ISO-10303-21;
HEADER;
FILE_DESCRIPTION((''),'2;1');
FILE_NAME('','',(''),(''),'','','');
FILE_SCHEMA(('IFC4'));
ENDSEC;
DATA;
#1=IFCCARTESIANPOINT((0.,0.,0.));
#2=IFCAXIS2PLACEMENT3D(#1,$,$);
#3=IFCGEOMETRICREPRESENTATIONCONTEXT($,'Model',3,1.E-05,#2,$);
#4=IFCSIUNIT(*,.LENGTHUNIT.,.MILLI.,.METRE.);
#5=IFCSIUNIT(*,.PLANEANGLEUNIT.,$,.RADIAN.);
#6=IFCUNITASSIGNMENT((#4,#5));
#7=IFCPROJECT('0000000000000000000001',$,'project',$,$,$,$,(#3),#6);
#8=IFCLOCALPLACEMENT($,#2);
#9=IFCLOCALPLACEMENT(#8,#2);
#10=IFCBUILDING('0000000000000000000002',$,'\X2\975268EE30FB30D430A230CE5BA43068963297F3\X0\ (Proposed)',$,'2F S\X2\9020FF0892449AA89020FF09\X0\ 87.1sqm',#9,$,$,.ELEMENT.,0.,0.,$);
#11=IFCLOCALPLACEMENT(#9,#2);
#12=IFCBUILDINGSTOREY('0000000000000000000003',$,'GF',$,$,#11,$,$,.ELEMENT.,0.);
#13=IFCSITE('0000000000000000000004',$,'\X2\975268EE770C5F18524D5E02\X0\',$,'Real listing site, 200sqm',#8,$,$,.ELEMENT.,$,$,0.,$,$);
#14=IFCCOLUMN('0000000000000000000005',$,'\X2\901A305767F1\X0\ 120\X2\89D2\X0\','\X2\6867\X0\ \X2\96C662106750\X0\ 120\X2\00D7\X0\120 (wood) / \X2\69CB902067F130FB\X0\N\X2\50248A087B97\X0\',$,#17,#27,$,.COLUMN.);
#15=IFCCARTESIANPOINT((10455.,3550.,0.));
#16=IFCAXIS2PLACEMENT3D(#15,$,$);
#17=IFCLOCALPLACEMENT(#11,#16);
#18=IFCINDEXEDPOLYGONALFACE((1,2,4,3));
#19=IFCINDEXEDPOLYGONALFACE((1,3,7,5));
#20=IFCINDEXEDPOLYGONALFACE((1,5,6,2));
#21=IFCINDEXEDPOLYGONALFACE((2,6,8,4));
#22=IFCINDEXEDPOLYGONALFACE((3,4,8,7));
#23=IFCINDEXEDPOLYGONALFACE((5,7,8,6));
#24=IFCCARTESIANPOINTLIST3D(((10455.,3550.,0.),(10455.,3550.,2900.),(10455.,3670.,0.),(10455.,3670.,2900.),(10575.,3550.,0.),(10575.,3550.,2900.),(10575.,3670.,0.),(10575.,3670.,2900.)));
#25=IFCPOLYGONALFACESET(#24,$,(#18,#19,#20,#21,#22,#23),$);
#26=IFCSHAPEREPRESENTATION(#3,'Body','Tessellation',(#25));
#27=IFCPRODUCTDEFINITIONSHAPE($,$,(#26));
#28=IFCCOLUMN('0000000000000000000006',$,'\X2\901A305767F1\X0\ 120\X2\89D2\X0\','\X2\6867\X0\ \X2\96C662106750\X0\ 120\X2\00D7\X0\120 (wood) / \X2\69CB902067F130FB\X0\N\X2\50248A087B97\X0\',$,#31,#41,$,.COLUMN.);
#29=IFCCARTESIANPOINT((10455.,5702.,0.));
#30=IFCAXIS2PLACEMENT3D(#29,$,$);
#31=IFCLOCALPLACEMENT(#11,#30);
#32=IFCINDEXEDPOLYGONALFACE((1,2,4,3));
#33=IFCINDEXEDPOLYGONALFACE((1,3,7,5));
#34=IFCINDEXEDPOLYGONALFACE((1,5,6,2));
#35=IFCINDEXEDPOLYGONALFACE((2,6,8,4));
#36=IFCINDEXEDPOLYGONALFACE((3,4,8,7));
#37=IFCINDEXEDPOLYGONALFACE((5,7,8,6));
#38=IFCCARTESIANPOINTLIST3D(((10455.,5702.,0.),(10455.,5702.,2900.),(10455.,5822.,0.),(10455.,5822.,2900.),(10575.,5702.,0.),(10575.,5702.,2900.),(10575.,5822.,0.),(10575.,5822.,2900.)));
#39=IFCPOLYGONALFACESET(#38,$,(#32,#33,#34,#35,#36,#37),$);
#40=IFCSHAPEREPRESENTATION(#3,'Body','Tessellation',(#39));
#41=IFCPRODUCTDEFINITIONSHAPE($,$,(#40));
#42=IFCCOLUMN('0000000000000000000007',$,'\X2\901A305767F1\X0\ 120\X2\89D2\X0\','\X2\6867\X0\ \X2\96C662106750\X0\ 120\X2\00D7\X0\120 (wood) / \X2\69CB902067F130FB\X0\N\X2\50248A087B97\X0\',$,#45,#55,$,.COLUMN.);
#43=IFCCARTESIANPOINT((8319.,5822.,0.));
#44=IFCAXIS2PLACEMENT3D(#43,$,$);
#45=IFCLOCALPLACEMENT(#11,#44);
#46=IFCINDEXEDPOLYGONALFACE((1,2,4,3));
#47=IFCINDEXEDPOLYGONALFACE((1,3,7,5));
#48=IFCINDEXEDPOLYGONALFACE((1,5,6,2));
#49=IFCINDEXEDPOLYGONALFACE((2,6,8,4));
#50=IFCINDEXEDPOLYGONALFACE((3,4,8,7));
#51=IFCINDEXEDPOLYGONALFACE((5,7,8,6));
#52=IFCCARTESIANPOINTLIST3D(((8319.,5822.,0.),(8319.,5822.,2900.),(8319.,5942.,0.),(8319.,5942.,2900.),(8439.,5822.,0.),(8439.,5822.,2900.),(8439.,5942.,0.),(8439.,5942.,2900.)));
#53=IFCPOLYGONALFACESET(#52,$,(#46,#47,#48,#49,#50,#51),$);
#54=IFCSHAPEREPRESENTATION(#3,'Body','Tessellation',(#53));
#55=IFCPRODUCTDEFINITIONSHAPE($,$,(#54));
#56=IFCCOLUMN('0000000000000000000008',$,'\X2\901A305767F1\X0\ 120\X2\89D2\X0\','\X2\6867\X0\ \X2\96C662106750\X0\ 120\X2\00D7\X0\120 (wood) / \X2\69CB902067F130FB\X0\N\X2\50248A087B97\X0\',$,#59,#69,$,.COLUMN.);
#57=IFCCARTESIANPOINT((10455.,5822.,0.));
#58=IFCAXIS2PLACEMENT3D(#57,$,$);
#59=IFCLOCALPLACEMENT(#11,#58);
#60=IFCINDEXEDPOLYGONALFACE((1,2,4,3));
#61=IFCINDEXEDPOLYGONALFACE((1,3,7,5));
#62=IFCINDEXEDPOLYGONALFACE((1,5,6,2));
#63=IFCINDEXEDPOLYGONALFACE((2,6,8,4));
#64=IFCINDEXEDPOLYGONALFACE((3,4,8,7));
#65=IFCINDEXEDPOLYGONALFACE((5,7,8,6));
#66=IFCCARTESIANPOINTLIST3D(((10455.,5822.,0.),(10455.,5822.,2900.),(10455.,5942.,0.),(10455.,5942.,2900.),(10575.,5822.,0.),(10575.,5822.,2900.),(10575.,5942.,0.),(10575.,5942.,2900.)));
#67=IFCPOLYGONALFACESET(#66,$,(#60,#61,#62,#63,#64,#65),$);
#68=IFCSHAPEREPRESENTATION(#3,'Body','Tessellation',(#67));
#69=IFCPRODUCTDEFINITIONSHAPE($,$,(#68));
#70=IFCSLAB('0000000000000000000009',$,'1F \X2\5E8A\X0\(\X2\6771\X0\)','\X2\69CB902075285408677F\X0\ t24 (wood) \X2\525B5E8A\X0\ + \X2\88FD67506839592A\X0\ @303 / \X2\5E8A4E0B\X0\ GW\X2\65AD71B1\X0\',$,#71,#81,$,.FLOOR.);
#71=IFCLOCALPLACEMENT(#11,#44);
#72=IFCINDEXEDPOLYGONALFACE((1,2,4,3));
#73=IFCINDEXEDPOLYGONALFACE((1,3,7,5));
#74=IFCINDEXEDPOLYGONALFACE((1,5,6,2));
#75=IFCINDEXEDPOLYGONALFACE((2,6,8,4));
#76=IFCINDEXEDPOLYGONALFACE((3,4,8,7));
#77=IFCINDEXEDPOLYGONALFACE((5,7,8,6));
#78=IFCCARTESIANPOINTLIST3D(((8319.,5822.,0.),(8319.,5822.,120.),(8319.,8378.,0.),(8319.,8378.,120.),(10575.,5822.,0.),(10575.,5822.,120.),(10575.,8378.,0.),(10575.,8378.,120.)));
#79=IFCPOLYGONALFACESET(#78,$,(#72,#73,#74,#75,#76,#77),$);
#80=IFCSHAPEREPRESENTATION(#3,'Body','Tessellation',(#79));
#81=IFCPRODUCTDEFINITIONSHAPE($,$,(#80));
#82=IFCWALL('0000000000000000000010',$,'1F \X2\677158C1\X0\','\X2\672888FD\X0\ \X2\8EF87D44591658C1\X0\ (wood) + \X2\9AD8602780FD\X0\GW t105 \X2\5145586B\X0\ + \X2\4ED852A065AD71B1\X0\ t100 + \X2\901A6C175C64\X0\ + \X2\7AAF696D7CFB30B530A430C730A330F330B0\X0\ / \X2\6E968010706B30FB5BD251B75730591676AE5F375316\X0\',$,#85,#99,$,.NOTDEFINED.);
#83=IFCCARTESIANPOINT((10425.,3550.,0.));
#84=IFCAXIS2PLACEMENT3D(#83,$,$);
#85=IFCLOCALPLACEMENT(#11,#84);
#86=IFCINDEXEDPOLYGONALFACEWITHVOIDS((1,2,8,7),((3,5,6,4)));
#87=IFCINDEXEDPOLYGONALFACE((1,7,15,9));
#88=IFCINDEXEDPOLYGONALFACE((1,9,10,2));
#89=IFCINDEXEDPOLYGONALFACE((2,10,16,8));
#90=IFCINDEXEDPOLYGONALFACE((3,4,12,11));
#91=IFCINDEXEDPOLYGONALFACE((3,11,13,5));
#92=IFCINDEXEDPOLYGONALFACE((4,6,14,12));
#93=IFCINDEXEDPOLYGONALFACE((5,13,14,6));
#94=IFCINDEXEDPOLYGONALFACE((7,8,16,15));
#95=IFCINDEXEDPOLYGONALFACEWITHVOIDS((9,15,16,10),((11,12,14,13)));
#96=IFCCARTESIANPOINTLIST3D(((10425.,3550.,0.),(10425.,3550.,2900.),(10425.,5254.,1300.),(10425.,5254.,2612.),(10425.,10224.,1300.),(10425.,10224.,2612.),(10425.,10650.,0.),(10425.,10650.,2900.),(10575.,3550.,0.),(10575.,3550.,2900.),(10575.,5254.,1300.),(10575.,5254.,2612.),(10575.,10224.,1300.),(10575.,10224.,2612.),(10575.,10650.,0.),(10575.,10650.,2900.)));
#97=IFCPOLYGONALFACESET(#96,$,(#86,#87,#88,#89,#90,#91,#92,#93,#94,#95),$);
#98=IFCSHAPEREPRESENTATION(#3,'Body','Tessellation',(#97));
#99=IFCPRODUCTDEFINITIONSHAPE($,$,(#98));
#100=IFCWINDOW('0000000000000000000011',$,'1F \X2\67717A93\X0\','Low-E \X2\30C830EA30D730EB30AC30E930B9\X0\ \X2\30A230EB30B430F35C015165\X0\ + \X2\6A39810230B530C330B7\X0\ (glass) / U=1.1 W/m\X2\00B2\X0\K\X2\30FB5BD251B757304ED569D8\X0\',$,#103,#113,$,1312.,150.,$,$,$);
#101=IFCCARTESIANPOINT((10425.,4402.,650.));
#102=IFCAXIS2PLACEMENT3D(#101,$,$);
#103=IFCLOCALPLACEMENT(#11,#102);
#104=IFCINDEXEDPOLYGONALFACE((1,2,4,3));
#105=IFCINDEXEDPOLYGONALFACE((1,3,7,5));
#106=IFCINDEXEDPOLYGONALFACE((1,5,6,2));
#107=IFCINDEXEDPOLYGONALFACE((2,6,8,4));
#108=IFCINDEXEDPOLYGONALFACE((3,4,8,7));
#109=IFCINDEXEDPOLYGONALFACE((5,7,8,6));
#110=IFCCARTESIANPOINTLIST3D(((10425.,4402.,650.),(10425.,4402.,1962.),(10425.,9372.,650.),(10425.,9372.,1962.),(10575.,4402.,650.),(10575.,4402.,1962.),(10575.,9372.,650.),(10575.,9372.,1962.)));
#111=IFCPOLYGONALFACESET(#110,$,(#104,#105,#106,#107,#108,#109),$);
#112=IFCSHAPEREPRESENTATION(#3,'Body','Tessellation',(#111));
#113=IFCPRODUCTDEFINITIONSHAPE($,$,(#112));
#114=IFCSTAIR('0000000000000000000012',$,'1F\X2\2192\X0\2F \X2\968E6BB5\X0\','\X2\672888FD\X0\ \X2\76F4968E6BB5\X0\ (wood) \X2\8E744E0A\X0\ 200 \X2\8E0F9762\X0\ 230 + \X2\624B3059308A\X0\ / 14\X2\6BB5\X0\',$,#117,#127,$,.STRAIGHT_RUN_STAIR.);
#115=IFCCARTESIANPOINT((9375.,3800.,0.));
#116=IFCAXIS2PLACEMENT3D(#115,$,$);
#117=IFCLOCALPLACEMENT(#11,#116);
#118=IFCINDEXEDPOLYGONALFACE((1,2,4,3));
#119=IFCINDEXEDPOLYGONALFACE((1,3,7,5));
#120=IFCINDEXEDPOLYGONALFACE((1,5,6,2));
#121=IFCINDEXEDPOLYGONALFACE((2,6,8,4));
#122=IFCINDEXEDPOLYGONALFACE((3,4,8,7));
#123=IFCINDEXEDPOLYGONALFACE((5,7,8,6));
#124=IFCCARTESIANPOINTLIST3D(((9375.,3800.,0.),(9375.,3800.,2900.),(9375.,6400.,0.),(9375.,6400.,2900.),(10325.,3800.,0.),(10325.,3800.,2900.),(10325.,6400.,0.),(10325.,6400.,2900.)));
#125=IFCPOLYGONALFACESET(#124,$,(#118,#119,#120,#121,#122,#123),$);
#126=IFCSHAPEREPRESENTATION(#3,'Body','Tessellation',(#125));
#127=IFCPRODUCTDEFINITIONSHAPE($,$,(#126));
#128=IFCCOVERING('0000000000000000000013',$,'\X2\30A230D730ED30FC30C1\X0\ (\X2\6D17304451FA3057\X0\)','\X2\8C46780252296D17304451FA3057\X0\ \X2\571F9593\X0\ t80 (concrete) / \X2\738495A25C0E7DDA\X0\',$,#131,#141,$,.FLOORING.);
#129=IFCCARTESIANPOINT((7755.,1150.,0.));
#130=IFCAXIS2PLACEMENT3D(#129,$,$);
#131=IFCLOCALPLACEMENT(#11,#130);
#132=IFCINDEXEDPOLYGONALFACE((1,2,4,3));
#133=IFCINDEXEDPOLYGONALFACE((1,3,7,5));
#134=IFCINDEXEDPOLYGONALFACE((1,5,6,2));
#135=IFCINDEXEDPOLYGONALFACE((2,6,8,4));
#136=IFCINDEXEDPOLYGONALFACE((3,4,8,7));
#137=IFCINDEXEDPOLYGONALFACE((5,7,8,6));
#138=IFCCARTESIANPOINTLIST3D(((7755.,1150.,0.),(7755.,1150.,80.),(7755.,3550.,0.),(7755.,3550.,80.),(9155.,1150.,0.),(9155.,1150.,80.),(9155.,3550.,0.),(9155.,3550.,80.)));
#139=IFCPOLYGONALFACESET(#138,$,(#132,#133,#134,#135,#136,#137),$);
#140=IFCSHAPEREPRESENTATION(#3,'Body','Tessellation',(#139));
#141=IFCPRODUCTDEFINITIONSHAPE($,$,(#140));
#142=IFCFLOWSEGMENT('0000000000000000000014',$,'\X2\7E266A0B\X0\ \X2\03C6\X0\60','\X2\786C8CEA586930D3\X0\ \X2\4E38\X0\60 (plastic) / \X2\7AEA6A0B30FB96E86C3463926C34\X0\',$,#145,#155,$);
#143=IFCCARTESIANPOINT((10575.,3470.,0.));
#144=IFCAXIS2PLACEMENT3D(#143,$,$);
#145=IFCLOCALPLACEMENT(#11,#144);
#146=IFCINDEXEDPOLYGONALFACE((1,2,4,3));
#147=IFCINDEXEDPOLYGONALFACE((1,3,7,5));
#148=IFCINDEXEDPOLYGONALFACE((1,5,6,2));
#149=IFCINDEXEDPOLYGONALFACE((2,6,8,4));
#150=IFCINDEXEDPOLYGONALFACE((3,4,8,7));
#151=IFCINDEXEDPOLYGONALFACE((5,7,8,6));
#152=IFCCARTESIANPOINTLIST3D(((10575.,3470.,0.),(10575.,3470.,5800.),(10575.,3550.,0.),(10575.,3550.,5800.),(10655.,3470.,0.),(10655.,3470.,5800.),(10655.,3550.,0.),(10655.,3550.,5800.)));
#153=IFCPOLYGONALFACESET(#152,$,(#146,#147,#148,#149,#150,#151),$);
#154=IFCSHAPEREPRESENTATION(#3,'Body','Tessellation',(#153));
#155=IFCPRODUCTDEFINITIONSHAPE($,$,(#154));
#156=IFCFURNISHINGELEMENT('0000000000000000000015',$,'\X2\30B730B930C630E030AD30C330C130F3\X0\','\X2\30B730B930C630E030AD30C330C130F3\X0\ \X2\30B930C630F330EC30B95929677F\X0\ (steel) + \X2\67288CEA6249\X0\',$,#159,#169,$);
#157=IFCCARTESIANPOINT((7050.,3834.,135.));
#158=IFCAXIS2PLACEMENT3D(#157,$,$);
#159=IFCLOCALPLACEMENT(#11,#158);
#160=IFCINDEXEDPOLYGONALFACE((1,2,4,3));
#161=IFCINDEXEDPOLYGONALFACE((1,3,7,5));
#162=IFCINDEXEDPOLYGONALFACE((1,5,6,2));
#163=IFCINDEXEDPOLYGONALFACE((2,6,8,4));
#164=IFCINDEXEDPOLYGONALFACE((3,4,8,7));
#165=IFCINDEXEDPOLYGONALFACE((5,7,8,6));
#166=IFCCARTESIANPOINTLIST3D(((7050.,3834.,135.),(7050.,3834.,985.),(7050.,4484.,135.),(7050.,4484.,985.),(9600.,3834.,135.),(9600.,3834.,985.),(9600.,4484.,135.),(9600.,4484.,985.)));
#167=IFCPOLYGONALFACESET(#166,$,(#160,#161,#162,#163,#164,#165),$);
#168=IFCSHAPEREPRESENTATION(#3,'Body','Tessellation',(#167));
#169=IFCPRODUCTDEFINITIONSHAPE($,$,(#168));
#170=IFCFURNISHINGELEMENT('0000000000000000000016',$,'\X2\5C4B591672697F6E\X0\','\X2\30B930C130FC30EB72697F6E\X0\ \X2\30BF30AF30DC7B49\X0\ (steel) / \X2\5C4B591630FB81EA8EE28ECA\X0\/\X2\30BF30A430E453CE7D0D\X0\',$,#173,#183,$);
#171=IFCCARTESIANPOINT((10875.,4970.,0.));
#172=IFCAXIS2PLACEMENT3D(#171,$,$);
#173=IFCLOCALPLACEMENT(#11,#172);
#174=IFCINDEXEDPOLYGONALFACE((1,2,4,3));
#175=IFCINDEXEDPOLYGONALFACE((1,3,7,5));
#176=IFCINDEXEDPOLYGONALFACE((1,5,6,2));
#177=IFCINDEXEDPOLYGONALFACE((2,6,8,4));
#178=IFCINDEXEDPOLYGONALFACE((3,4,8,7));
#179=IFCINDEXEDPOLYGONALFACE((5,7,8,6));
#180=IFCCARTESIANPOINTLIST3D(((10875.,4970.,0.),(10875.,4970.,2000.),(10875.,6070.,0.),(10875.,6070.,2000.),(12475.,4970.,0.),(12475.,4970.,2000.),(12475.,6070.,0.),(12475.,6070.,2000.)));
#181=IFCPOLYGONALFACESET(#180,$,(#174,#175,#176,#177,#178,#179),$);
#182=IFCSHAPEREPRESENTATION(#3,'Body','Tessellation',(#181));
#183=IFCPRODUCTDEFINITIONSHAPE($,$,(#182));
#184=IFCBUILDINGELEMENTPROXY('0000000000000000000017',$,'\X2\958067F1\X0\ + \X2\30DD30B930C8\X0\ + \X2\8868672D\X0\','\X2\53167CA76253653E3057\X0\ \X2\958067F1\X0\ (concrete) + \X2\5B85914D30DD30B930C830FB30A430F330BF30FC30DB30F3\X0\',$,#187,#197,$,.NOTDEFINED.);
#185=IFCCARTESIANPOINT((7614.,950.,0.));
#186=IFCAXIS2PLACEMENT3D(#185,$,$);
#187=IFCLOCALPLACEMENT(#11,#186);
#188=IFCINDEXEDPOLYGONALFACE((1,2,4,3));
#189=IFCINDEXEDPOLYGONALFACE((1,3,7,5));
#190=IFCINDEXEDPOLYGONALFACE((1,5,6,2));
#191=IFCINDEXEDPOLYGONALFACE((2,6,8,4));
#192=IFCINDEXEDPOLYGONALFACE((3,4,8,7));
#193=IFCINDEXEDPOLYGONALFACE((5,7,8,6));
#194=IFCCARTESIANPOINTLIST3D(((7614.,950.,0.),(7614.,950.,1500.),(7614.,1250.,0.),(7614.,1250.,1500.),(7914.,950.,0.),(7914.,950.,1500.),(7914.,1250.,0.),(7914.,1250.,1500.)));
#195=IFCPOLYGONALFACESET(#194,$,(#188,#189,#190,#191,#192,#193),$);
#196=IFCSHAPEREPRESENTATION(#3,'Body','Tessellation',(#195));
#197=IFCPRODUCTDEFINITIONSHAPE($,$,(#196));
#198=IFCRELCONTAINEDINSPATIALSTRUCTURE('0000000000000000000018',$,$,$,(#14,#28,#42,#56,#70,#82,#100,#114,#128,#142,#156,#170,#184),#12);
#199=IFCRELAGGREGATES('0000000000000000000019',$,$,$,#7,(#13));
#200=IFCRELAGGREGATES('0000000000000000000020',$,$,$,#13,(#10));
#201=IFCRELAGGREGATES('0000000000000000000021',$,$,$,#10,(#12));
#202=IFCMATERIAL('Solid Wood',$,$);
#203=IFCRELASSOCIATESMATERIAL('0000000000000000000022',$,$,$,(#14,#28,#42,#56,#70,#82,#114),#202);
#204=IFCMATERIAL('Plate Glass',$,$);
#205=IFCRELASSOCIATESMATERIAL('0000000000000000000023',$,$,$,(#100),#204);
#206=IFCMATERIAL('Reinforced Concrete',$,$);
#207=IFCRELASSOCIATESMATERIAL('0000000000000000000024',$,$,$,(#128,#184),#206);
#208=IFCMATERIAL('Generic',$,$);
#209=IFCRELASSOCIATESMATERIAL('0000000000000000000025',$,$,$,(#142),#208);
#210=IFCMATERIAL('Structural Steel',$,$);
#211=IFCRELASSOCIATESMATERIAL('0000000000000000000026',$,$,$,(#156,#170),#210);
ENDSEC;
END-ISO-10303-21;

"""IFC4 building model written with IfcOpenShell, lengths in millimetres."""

from ifc_helpers import new_model, si_unit, frame, frame_2d, origin, place, context, project, spatial, rectangle, extrude, material, element, fill, save


model = new_model("IFC4")

# Units and contexts
model_context = context("Model", 3, precision=1e-05, world=origin())
ifc_project = project(units=[si_unit("LENGTHUNIT", "METRE", prefix="MILLI"), si_unit("PLANEANGLEUNIT", "RADIAN")], contexts=[model_context])

# Site, building, storey
site_placement = place(None, origin())
site = spatial("IfcSite", under=ifc_project, at=site_placement, Name="青森県弘前市", ObjectType="Real listing site, 200sqm", CompositionType="ELEMENT", RefElevation=0.0)
building_placement = place(site_placement, origin())
building = spatial("IfcBuilding", under=site, at=building_placement, Name="青森・ピアノ室と防音 (Proposed)", ObjectType="2F S造（鉄骨造） 87.1sqm", CompositionType="ELEMENT", ElevationOfRefHeight=0.0, ElevationOfTerrain=0.0)
storey_placement = place(building_placement, origin())
storey = spatial("IfcBuildingStorey", under=building, at=storey_placement, Name="GF", CompositionType="ELEMENT", Elevation=0.0)

# Columns
ifc_material_1 = material(Name="Solid Wood")
column_1_placement = place(storey_placement, frame((10455.0, 3550.0, 0.0)))
element("IfcColumn", 1, at=column_1_placement, inside=storey, material=ifc_material_1, Name="通し柱 120角", Description="桧 集成材 120×120 (wood) / 構造柱・N値計算", PredefinedType="COLUMN", context=model_context, shape_type="SweptSolid", body=[
    extrude(rectangle(XDim=120.0, YDim=120.0, at=frame_2d((60.0, 60.0))), frame((10455.0, 3550.0, 0.0)), (0.0, 0.0, 1.0), 2900.0),
])
column_2_placement = place(storey_placement, frame((10455.0, 5702.0, 0.0)))
element("IfcColumn", 2, at=column_2_placement, inside=storey, material=ifc_material_1, Name="通し柱 120角", Description="桧 集成材 120×120 (wood) / 構造柱・N値計算", PredefinedType="COLUMN", context=model_context, shape_type="SweptSolid", body=[
    extrude(rectangle(XDim=120.0, YDim=120.0, at=frame_2d((60.0, 60.0))), frame((10455.0, 5702.0, 0.0)), (0.0, 0.0, 1.0), 2900.0),
])
column_3_placement = place(storey_placement, frame((8319.0, 5822.0, 0.0)))
element("IfcColumn", 3, at=column_3_placement, inside=storey, material=ifc_material_1, Name="通し柱 120角", Description="桧 集成材 120×120 (wood) / 構造柱・N値計算", PredefinedType="COLUMN", context=model_context, shape_type="SweptSolid", body=[
    extrude(rectangle(XDim=120.0, YDim=120.0, at=frame_2d((60.0, 60.0))), frame((8319.0, 5822.0, 0.0)), (0.0, 0.0, 1.0), 2900.0),
])
column_4_placement = place(storey_placement, frame((10455.0, 5822.0, 0.0)))
element("IfcColumn", 4, at=column_4_placement, inside=storey, material=ifc_material_1, Name="通し柱 120角", Description="桧 集成材 120×120 (wood) / 構造柱・N値計算", PredefinedType="COLUMN", context=model_context, shape_type="SweptSolid", body=[
    extrude(rectangle(XDim=120.0, YDim=120.0, at=frame_2d((60.0, 60.0))), frame((10455.0, 5822.0, 0.0)), (0.0, 0.0, 1.0), 2900.0),
])

# Slab
slab_placement = place(storey_placement, frame((8319.0, 5822.0, 0.0)))
element("IfcSlab", 5, at=slab_placement, inside=storey, material=ifc_material_1, Name="1F 床(東)", Description="構造用合板 t24 (wood) 剛床 + 製材根太 @303 / 床下 GW断熱", PredefinedType="FLOOR", context=model_context, shape_type="SweptSolid", body=[
    extrude(rectangle(XDim=2256.0, YDim=2556.0, at=frame_2d((1128.0, 1278.0))), frame((8319.0, 5822.0, 0.0)), (0.0, 0.0, 1.0), 120.0),
])

# Wall, opening, window
wall_1_placement = place(storey_placement, frame((10425.0, 3550.0, 0.0)))
wall_1 = element("IfcWall", 6, at=wall_1_placement, inside=storey, material=ifc_material_1, Name="1F 東壁", Description="木製 軸組外壁 (wood) + 高性能GW t105 充填 + 付加断熱 t100 + 通気層 + 窯業系サイディング / 準耐火・寒冷地外皮強化", PredefinedType="NOTDEFINED", context=model_context, shape_type="SweptSolid", body=[
    extrude(rectangle(XDim=150.0, YDim=7100.0, at=frame_2d((75.0, 3550.0))), frame((10425.0, 3550.0, 0.0)), (0.0, 0.0, 1.0), 2900.0),
])
opening_placement = place(storey_placement, frame((10425.0, 4402.0, 650.0)))
opening = element("IfcOpeningElement", 7, at=opening_placement, cuts=wall_1, PredefinedType="NOTDEFINED", context=model_context, shape_type="SweptSolid", body=[
    extrude(rectangle(XDim=150.0, YDim=4970.0, at=frame_2d((75.0, 2485.0))), frame((10425.0, 4402.0, 650.0)), (0.0, 0.0, 1.0), 1312.0),
])
ifc_material_2 = material(Name="Plate Glass")
window_placement = place(storey_placement, frame((10425.0, 4402.0, 650.0)))
window = element("IfcWindow", 8, at=window_placement, inside=storey, material=ifc_material_2, Name="1F 東窓", Description="Low-E トリプルガラス アルゴン封入 + 樹脂サッシ (glass) / U=1.1 W/m²K・寒冷地仕様", OverallHeight=1312.0, OverallWidth=150.0, context=model_context, shape_type="SweptSolid", body=[
    extrude(rectangle(XDim=150.0, YDim=4970.0, at=frame_2d((75.0, 2485.0))), frame((10425.0, 4402.0, 650.0)), (0.0, 0.0, 1.0), 1312.0),
])
fill(opening, window)

# Stair
stair_placement = place(storey_placement, frame((9375.0, 3800.0, 0.0)))
element("IfcStair", 9, at=stair_placement, inside=storey, material=ifc_material_1, Name="1F→2F 階段", Description="木製 直階段 (wood) 蹴上 200 踏面 230 + 手すり / 14段", PredefinedType="STRAIGHT_RUN_STAIR", context=model_context, shape_type="SweptSolid", body=[
    extrude(rectangle(XDim=950.0, YDim=2600.0, at=frame_2d((475.0, 1300.0))), frame((9375.0, 3800.0, 0.0)), (0.0, 0.0, 1.0), 2900.0),
])

# Covering
ifc_material_3 = material(Name="Reinforced Concrete")
covering_placement = place(storey_placement, frame((7755.0, 1150.0, 0.0)))
element("IfcCovering", 10, at=covering_placement, inside=storey, material=ifc_material_3, Name="アプローチ (洗い出し)", Description="豆砂利洗い出し 土間 t80 (concrete) / 玄関導線", PredefinedType="FLOORING", context=model_context, shape_type="SweptSolid", body=[
    extrude(rectangle(XDim=1400.0, YDim=2400.0, at=frame_2d((700.0, 1200.0))), frame((7755.0, 1150.0, 0.0)), (0.0, 0.0, 1.0), 80.0),
])

# Flow segment
ifc_material_4 = material(Name="Generic")
flow_segment_placement = place(storey_placement, frame((10575.0, 3470.0, 0.0)))
element("IfcFlowSegment", 11, at=flow_segment_placement, inside=storey, material=ifc_material_4, Name="縦樋 φ60", Description="硬質塩ビ 丸60 (plastic) / 竪樋・雨水排水", context=model_context, shape_type="SweptSolid", body=[
    extrude(rectangle(XDim=80.0, YDim=80.0, at=frame_2d((40.0, 40.0))), frame((10575.0, 3470.0, 0.0)), (0.0, 0.0, 1.0), 5800.0),
])

# Furnishing elements
ifc_material_5 = material(Name="Structural Steel")
furnishing_1_placement = place(storey_placement, frame((7050.0, 3834.0, 135.0)))
element("IfcFurnishingElement", 12, at=furnishing_1_placement, inside=storey, material=ifc_material_5, Name="システムキッチン", Description="システムキッチン ステンレス天板 (steel) + 木質扉", context=model_context, shape_type="SweptSolid", body=[
    extrude(rectangle(XDim=2550.0, YDim=650.0, at=frame_2d((1275.0, 325.0))), frame((7050.0, 3834.0, 135.0)), (0.0, 0.0, 1.0), 850.0),
])
furnishing_2_placement = place(storey_placement, frame((10875.0, 4970.0, 0.0)))
element("IfcFurnishingElement", 13, at=furnishing_2_placement, inside=storey, material=ifc_material_5, Name="屋外物置", Description="スチール物置 タクボ等 (steel) / 屋外・自転車/タイヤ収納", context=model_context, shape_type="SweptSolid", body=[
    extrude(rectangle(XDim=1600.0, YDim=1100.0, at=frame_2d((800.0, 550.0))), frame((10875.0, 4970.0, 0.0)), (0.0, 0.0, 1.0), 2000.0),
])

# Building element proxy
proxy_placement = place(storey_placement, frame((7614.0, 950.0, 0.0)))
element("IfcBuildingElementProxy", 14, at=proxy_placement, inside=storey, material=ifc_material_3, Name="門柱 + ポスト + 表札", Description="化粧打放し 門柱 (concrete) + 宅配ポスト・インターホン", PredefinedType="NOTDEFINED", context=model_context, shape_type="SweptSolid", body=[
    extrude(rectangle(XDim=300.0, YDim=300.0, at=frame_2d((150.0, 150.0))), frame((7614.0, 950.0, 0.0)), (0.0, 0.0, 1.0), 1500.0),
])

save(model, "model.ifc")
